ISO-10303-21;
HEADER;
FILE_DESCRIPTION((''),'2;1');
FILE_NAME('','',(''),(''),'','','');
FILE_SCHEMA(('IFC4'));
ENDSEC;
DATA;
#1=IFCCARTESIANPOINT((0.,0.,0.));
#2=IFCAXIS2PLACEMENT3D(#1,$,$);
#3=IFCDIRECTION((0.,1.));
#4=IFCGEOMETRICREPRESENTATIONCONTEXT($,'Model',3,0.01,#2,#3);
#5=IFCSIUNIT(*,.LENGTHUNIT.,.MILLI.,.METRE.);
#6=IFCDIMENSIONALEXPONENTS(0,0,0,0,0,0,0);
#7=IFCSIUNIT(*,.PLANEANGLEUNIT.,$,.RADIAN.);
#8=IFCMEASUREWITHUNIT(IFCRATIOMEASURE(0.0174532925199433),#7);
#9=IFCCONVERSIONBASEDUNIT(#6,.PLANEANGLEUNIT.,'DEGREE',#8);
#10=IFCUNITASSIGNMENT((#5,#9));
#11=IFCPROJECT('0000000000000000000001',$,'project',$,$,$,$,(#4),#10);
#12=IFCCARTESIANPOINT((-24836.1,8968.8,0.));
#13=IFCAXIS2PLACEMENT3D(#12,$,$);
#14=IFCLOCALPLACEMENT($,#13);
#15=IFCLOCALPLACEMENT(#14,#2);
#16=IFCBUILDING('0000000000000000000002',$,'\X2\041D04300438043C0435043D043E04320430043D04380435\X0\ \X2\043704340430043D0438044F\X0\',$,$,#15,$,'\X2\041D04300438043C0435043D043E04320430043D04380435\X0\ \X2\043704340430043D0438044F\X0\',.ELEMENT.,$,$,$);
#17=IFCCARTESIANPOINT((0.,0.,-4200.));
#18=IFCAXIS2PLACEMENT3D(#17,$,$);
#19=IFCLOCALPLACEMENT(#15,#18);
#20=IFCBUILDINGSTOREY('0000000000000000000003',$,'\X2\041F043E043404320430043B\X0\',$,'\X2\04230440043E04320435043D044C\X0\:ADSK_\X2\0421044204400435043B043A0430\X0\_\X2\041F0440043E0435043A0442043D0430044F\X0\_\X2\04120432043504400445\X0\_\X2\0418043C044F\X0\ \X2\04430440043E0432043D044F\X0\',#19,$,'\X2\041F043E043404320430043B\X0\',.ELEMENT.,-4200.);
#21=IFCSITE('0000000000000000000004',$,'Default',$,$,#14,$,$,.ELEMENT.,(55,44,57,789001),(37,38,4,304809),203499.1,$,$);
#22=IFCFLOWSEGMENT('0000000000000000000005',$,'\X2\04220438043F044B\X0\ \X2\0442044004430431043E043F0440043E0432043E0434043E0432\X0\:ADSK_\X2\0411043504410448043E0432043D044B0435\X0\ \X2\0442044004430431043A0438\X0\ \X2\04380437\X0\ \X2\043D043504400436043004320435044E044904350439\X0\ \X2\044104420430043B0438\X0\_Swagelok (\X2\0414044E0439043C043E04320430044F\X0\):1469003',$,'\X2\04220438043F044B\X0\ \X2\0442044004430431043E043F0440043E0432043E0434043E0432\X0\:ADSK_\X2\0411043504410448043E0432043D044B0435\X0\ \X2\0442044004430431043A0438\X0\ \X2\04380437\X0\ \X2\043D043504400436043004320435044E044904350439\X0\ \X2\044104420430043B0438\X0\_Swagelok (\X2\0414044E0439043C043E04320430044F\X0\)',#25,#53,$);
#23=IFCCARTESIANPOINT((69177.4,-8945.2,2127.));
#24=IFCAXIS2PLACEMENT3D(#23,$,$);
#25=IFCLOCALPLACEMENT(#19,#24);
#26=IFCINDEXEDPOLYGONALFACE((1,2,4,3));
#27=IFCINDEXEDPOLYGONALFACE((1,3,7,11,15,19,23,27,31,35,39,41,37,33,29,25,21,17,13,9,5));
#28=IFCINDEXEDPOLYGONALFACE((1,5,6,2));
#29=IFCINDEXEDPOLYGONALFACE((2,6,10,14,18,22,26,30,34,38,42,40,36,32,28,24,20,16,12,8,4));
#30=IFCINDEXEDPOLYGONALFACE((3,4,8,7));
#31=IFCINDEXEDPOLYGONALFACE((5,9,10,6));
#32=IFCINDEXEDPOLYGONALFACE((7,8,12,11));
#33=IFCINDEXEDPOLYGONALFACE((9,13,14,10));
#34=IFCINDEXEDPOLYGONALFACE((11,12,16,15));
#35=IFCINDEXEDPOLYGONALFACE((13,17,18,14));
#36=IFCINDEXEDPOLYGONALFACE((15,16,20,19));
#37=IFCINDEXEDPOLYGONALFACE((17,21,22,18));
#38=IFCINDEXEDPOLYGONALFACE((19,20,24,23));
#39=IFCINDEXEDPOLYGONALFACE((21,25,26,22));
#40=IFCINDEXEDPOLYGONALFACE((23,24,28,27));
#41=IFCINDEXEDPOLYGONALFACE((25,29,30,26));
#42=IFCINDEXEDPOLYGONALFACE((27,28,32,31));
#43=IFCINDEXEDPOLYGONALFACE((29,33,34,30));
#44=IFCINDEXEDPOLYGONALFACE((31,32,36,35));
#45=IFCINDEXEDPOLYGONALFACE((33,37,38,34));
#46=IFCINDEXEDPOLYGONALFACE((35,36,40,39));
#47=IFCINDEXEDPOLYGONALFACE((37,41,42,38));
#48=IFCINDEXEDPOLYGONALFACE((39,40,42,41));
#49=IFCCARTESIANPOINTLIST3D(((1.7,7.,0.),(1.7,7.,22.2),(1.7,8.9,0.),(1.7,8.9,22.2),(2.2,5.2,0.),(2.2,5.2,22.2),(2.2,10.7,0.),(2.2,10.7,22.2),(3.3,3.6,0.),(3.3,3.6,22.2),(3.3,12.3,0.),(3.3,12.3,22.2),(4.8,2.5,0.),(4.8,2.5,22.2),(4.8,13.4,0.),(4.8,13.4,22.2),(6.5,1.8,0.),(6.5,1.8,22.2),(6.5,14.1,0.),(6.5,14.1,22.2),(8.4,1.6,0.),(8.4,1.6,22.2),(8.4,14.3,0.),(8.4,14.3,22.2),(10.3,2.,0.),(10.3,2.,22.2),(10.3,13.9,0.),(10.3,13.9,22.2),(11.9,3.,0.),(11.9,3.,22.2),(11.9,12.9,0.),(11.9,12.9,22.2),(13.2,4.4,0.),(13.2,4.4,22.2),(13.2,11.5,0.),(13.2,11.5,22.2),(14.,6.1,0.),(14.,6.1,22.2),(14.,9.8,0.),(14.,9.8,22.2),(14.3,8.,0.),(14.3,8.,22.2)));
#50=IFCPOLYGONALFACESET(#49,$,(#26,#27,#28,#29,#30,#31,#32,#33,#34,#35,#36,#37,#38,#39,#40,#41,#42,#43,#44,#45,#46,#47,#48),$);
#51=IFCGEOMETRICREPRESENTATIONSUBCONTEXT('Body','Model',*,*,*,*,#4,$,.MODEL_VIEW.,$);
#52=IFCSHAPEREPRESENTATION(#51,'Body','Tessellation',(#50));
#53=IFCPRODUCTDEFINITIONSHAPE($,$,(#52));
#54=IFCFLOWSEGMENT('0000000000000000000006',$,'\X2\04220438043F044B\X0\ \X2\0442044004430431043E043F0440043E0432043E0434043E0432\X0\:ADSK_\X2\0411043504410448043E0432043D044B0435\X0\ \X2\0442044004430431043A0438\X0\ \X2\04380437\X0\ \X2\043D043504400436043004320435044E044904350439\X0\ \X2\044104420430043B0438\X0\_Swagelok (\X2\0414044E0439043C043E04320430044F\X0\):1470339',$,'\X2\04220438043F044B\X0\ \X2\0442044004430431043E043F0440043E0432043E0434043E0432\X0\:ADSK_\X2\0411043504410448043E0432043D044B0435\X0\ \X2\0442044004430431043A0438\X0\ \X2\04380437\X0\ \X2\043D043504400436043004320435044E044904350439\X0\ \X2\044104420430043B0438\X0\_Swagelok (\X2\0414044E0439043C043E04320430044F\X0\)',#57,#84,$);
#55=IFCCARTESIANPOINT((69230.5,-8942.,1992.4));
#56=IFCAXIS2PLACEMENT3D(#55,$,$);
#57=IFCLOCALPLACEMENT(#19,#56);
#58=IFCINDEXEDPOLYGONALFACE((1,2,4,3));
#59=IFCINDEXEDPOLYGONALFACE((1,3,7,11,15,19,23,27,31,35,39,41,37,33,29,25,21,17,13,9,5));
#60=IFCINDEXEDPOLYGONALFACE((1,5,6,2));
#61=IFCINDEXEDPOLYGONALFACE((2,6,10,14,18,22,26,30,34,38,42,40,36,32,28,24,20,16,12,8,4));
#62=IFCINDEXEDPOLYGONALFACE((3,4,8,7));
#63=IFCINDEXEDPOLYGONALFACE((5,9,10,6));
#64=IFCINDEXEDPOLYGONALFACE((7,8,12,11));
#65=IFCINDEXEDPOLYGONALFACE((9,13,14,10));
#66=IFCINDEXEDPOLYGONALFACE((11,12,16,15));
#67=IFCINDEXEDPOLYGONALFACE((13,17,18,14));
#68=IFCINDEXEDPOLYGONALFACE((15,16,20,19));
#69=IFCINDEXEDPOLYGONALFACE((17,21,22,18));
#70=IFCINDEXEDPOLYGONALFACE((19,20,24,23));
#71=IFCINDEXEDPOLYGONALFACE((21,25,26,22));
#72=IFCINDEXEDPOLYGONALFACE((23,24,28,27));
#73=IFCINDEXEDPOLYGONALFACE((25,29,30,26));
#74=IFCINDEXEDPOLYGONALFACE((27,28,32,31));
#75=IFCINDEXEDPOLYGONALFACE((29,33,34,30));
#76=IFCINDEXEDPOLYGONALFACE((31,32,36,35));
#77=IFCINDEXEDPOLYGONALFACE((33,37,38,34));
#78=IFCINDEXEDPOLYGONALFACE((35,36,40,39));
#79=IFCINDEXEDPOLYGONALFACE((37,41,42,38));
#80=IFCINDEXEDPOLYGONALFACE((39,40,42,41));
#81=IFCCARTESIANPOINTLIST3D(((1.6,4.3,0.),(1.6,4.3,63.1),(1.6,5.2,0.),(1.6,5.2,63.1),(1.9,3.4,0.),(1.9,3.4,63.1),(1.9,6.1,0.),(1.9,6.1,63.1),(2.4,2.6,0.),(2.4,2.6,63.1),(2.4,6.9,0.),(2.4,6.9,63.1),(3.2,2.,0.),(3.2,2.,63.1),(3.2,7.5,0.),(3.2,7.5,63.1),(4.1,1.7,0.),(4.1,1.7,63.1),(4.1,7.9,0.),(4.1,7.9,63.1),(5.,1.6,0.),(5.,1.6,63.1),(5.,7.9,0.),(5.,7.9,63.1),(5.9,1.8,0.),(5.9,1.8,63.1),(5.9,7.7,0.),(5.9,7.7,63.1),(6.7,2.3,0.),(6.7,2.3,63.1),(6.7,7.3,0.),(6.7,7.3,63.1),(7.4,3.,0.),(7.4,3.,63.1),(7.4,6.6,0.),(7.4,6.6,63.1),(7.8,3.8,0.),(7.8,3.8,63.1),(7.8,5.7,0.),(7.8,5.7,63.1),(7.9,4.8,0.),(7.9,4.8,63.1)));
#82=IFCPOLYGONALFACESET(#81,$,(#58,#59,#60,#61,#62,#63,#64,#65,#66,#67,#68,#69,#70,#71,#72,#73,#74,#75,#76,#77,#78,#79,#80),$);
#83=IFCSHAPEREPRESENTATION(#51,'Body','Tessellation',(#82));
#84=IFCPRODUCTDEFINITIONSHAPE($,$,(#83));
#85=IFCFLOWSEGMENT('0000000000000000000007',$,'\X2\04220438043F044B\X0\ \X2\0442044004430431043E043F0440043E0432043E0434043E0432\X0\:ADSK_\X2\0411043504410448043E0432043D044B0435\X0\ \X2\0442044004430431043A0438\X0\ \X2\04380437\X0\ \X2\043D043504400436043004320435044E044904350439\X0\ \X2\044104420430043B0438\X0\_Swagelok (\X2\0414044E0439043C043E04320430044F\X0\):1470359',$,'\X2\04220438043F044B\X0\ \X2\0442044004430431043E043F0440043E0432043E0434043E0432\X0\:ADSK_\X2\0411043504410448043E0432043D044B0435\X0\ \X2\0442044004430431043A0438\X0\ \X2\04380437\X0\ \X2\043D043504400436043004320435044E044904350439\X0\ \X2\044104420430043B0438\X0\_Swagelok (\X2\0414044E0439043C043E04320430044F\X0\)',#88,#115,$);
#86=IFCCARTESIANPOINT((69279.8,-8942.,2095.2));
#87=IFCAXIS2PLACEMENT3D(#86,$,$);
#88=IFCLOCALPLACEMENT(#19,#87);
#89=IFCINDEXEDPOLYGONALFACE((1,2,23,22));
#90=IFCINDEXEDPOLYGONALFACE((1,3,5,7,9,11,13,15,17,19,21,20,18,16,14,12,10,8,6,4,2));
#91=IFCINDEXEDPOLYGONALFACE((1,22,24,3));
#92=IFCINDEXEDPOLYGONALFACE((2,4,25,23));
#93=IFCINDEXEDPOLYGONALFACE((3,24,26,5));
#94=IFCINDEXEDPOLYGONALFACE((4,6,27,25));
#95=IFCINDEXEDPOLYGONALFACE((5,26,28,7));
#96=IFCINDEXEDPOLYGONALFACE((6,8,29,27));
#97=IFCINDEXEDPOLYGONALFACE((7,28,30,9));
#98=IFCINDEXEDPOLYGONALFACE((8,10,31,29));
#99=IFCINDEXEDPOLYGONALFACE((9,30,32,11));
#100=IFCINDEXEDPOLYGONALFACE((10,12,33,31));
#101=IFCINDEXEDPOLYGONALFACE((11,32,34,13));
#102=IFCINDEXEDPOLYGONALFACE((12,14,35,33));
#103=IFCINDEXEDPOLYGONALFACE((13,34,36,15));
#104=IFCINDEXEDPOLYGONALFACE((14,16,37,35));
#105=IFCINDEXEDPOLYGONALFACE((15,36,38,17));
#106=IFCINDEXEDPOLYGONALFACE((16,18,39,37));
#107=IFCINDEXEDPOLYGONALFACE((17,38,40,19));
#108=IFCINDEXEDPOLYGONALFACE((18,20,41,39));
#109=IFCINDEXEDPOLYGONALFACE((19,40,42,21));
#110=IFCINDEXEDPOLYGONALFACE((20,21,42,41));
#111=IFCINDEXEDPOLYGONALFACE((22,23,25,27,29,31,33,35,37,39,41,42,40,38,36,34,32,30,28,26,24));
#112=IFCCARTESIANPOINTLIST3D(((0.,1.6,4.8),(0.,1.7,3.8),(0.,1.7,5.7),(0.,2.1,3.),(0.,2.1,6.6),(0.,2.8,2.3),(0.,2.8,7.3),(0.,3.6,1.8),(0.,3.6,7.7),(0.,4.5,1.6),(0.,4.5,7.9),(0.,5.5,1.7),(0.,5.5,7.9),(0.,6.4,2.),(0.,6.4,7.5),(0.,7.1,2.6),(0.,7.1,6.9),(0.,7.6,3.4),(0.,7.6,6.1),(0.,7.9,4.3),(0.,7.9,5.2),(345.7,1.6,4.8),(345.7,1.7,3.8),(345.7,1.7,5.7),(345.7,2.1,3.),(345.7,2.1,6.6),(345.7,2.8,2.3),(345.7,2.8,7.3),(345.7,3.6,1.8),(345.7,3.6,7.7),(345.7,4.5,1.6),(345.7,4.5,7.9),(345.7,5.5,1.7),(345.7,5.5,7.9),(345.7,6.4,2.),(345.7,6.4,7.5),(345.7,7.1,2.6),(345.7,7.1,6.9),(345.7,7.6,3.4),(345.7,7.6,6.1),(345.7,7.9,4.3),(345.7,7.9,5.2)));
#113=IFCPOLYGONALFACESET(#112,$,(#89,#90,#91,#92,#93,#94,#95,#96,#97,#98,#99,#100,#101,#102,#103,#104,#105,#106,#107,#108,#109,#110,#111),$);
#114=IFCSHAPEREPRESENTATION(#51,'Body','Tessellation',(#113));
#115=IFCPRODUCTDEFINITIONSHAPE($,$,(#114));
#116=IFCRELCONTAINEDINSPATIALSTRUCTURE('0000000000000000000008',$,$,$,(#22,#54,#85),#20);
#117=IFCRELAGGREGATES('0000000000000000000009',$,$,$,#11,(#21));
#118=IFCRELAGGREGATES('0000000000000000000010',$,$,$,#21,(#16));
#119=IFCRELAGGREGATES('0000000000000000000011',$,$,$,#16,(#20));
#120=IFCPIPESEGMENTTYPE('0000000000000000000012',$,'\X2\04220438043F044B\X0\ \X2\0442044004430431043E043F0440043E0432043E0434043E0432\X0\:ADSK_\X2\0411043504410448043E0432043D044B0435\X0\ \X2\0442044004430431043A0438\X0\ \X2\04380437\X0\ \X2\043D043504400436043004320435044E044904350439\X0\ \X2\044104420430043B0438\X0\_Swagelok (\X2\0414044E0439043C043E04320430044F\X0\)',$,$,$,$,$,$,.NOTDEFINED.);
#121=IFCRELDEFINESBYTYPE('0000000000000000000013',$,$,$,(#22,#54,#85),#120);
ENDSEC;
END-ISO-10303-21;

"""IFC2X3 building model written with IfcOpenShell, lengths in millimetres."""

from ifc_helpers import new_model, entity, si_unit, converted_unit, direction, frame, origin, origin_2d_with_axis, place, context, subcontext, project, spatial, circle, extrude, type_object, element, save


model = new_model("IFC2X3")

# Units and contexts
model_context = context("Model", 3, precision=0.01, world=origin(), true_north=direction((0.0, 1.0)))
body_context = subcontext(model_context, "Body", "Model", "MODEL_VIEW")
ifc_project = project(units=[si_unit("LENGTHUNIT", "METRE", prefix="MILLI"), converted_unit("PLANEANGLEUNIT", "DEGREE", entity("IfcRatioMeasure", 0.0174532925199433), si_unit("PLANEANGLEUNIT", "RADIAN"), dimensions=[0, 0, 0, 0, 0, 0, 0])], contexts=[model_context])

# Site, building, storey
site_placement = place(None, frame((-24836.1, 8968.8, 0.0)))
site = spatial("IfcSite", under=ifc_project, at=site_placement, Name="Default", CompositionType="ELEMENT", RefLatitude=(55, 44, 57, 789001), RefLongitude=(37, 38, 4, 304809), RefElevation=203499.1)
building_placement = place(site_placement, origin())
building = spatial("IfcBuilding", under=site, at=building_placement, Name="Наименование здания", LongName="Наименование здания", CompositionType="ELEMENT")
storey_placement = place(building_placement, frame((0.0, 0.0, -4200.0)))
storey = spatial("IfcBuildingStorey", under=building, at=storey_placement, Name="Подвал", ObjectType="Уровень:ADSK_Стрелка_Проектная_Вверх_Имя уровня", LongName="Подвал", CompositionType="ELEMENT", Elevation=-4200.0)

# Flow segments
pipe_segment_type = type_object("IfcPipeSegmentType", Name="Типы трубопроводов:ADSK_Бесшовные трубки из нержавеющей стали_Swagelok (Дюймовая)", PredefinedType="NOTDEFINED")
flow_segment_1_placement = place(storey_placement, frame((69177.4, -8945.2, 2127.0)))
element("IfcFlowSegment", 1, at=flow_segment_1_placement, inside=storey, type_object=pipe_segment_type, Name="Типы трубопроводов:ADSK_Бесшовные трубки из нержавеющей стали_Swagelok (Дюймовая):1469003", ObjectType="Типы трубопроводов:ADSK_Бесшовные трубки из нержавеющей стали_Swagelok (Дюймовая)", context=body_context, shape_type="SweptSolid", body=[
    extrude(circle(Radius=6.3, at=origin_2d_with_axis()), frame((8.0, 8.0, 0.0)), (0.0, 0.0, 1.0), 22.2),
])
flow_segment_2_placement = place(storey_placement, frame((69230.5, -8942.0, 1992.4)))
element("IfcFlowSegment", 2, at=flow_segment_2_placement, inside=storey, type_object=pipe_segment_type, Name="Типы трубопроводов:ADSK_Бесшовные трубки из нержавеющей стали_Swagelok (Дюймовая):1470339", ObjectType="Типы трубопроводов:ADSK_Бесшовные трубки из нержавеющей стали_Swagelok (Дюймовая)", context=body_context, shape_type="SweptSolid", body=[
    extrude(circle(Radius=3.2, at=origin_2d_with_axis()), frame((4.8, 4.8, 0.0)), (0.0, 0.0, 1.0), 63.1),
])
flow_segment_3_placement = place(storey_placement, frame((69279.8, -8942.0, 2095.2)))
element("IfcFlowSegment", 3, at=flow_segment_3_placement, inside=storey, type_object=pipe_segment_type, Name="Типы трубопроводов:ADSK_Бесшовные трубки из нержавеющей стали_Swagelok (Дюймовая):1470359", ObjectType="Типы трубопроводов:ADSK_Бесшовные трубки из нержавеющей стали_Swagelok (Дюймовая)", context=body_context, shape_type="SweptSolid", body=[
    extrude(circle(Radius=3.2, at=origin_2d_with_axis()), frame((0.0, 4.8, 4.8), z_axis=(1.0, 0.0, 0.0), x_axis=(0.0, -1.0, 0.0)), (0.0, 0.0, 1.0), 345.7),
])

save(model, "model.ifc")
